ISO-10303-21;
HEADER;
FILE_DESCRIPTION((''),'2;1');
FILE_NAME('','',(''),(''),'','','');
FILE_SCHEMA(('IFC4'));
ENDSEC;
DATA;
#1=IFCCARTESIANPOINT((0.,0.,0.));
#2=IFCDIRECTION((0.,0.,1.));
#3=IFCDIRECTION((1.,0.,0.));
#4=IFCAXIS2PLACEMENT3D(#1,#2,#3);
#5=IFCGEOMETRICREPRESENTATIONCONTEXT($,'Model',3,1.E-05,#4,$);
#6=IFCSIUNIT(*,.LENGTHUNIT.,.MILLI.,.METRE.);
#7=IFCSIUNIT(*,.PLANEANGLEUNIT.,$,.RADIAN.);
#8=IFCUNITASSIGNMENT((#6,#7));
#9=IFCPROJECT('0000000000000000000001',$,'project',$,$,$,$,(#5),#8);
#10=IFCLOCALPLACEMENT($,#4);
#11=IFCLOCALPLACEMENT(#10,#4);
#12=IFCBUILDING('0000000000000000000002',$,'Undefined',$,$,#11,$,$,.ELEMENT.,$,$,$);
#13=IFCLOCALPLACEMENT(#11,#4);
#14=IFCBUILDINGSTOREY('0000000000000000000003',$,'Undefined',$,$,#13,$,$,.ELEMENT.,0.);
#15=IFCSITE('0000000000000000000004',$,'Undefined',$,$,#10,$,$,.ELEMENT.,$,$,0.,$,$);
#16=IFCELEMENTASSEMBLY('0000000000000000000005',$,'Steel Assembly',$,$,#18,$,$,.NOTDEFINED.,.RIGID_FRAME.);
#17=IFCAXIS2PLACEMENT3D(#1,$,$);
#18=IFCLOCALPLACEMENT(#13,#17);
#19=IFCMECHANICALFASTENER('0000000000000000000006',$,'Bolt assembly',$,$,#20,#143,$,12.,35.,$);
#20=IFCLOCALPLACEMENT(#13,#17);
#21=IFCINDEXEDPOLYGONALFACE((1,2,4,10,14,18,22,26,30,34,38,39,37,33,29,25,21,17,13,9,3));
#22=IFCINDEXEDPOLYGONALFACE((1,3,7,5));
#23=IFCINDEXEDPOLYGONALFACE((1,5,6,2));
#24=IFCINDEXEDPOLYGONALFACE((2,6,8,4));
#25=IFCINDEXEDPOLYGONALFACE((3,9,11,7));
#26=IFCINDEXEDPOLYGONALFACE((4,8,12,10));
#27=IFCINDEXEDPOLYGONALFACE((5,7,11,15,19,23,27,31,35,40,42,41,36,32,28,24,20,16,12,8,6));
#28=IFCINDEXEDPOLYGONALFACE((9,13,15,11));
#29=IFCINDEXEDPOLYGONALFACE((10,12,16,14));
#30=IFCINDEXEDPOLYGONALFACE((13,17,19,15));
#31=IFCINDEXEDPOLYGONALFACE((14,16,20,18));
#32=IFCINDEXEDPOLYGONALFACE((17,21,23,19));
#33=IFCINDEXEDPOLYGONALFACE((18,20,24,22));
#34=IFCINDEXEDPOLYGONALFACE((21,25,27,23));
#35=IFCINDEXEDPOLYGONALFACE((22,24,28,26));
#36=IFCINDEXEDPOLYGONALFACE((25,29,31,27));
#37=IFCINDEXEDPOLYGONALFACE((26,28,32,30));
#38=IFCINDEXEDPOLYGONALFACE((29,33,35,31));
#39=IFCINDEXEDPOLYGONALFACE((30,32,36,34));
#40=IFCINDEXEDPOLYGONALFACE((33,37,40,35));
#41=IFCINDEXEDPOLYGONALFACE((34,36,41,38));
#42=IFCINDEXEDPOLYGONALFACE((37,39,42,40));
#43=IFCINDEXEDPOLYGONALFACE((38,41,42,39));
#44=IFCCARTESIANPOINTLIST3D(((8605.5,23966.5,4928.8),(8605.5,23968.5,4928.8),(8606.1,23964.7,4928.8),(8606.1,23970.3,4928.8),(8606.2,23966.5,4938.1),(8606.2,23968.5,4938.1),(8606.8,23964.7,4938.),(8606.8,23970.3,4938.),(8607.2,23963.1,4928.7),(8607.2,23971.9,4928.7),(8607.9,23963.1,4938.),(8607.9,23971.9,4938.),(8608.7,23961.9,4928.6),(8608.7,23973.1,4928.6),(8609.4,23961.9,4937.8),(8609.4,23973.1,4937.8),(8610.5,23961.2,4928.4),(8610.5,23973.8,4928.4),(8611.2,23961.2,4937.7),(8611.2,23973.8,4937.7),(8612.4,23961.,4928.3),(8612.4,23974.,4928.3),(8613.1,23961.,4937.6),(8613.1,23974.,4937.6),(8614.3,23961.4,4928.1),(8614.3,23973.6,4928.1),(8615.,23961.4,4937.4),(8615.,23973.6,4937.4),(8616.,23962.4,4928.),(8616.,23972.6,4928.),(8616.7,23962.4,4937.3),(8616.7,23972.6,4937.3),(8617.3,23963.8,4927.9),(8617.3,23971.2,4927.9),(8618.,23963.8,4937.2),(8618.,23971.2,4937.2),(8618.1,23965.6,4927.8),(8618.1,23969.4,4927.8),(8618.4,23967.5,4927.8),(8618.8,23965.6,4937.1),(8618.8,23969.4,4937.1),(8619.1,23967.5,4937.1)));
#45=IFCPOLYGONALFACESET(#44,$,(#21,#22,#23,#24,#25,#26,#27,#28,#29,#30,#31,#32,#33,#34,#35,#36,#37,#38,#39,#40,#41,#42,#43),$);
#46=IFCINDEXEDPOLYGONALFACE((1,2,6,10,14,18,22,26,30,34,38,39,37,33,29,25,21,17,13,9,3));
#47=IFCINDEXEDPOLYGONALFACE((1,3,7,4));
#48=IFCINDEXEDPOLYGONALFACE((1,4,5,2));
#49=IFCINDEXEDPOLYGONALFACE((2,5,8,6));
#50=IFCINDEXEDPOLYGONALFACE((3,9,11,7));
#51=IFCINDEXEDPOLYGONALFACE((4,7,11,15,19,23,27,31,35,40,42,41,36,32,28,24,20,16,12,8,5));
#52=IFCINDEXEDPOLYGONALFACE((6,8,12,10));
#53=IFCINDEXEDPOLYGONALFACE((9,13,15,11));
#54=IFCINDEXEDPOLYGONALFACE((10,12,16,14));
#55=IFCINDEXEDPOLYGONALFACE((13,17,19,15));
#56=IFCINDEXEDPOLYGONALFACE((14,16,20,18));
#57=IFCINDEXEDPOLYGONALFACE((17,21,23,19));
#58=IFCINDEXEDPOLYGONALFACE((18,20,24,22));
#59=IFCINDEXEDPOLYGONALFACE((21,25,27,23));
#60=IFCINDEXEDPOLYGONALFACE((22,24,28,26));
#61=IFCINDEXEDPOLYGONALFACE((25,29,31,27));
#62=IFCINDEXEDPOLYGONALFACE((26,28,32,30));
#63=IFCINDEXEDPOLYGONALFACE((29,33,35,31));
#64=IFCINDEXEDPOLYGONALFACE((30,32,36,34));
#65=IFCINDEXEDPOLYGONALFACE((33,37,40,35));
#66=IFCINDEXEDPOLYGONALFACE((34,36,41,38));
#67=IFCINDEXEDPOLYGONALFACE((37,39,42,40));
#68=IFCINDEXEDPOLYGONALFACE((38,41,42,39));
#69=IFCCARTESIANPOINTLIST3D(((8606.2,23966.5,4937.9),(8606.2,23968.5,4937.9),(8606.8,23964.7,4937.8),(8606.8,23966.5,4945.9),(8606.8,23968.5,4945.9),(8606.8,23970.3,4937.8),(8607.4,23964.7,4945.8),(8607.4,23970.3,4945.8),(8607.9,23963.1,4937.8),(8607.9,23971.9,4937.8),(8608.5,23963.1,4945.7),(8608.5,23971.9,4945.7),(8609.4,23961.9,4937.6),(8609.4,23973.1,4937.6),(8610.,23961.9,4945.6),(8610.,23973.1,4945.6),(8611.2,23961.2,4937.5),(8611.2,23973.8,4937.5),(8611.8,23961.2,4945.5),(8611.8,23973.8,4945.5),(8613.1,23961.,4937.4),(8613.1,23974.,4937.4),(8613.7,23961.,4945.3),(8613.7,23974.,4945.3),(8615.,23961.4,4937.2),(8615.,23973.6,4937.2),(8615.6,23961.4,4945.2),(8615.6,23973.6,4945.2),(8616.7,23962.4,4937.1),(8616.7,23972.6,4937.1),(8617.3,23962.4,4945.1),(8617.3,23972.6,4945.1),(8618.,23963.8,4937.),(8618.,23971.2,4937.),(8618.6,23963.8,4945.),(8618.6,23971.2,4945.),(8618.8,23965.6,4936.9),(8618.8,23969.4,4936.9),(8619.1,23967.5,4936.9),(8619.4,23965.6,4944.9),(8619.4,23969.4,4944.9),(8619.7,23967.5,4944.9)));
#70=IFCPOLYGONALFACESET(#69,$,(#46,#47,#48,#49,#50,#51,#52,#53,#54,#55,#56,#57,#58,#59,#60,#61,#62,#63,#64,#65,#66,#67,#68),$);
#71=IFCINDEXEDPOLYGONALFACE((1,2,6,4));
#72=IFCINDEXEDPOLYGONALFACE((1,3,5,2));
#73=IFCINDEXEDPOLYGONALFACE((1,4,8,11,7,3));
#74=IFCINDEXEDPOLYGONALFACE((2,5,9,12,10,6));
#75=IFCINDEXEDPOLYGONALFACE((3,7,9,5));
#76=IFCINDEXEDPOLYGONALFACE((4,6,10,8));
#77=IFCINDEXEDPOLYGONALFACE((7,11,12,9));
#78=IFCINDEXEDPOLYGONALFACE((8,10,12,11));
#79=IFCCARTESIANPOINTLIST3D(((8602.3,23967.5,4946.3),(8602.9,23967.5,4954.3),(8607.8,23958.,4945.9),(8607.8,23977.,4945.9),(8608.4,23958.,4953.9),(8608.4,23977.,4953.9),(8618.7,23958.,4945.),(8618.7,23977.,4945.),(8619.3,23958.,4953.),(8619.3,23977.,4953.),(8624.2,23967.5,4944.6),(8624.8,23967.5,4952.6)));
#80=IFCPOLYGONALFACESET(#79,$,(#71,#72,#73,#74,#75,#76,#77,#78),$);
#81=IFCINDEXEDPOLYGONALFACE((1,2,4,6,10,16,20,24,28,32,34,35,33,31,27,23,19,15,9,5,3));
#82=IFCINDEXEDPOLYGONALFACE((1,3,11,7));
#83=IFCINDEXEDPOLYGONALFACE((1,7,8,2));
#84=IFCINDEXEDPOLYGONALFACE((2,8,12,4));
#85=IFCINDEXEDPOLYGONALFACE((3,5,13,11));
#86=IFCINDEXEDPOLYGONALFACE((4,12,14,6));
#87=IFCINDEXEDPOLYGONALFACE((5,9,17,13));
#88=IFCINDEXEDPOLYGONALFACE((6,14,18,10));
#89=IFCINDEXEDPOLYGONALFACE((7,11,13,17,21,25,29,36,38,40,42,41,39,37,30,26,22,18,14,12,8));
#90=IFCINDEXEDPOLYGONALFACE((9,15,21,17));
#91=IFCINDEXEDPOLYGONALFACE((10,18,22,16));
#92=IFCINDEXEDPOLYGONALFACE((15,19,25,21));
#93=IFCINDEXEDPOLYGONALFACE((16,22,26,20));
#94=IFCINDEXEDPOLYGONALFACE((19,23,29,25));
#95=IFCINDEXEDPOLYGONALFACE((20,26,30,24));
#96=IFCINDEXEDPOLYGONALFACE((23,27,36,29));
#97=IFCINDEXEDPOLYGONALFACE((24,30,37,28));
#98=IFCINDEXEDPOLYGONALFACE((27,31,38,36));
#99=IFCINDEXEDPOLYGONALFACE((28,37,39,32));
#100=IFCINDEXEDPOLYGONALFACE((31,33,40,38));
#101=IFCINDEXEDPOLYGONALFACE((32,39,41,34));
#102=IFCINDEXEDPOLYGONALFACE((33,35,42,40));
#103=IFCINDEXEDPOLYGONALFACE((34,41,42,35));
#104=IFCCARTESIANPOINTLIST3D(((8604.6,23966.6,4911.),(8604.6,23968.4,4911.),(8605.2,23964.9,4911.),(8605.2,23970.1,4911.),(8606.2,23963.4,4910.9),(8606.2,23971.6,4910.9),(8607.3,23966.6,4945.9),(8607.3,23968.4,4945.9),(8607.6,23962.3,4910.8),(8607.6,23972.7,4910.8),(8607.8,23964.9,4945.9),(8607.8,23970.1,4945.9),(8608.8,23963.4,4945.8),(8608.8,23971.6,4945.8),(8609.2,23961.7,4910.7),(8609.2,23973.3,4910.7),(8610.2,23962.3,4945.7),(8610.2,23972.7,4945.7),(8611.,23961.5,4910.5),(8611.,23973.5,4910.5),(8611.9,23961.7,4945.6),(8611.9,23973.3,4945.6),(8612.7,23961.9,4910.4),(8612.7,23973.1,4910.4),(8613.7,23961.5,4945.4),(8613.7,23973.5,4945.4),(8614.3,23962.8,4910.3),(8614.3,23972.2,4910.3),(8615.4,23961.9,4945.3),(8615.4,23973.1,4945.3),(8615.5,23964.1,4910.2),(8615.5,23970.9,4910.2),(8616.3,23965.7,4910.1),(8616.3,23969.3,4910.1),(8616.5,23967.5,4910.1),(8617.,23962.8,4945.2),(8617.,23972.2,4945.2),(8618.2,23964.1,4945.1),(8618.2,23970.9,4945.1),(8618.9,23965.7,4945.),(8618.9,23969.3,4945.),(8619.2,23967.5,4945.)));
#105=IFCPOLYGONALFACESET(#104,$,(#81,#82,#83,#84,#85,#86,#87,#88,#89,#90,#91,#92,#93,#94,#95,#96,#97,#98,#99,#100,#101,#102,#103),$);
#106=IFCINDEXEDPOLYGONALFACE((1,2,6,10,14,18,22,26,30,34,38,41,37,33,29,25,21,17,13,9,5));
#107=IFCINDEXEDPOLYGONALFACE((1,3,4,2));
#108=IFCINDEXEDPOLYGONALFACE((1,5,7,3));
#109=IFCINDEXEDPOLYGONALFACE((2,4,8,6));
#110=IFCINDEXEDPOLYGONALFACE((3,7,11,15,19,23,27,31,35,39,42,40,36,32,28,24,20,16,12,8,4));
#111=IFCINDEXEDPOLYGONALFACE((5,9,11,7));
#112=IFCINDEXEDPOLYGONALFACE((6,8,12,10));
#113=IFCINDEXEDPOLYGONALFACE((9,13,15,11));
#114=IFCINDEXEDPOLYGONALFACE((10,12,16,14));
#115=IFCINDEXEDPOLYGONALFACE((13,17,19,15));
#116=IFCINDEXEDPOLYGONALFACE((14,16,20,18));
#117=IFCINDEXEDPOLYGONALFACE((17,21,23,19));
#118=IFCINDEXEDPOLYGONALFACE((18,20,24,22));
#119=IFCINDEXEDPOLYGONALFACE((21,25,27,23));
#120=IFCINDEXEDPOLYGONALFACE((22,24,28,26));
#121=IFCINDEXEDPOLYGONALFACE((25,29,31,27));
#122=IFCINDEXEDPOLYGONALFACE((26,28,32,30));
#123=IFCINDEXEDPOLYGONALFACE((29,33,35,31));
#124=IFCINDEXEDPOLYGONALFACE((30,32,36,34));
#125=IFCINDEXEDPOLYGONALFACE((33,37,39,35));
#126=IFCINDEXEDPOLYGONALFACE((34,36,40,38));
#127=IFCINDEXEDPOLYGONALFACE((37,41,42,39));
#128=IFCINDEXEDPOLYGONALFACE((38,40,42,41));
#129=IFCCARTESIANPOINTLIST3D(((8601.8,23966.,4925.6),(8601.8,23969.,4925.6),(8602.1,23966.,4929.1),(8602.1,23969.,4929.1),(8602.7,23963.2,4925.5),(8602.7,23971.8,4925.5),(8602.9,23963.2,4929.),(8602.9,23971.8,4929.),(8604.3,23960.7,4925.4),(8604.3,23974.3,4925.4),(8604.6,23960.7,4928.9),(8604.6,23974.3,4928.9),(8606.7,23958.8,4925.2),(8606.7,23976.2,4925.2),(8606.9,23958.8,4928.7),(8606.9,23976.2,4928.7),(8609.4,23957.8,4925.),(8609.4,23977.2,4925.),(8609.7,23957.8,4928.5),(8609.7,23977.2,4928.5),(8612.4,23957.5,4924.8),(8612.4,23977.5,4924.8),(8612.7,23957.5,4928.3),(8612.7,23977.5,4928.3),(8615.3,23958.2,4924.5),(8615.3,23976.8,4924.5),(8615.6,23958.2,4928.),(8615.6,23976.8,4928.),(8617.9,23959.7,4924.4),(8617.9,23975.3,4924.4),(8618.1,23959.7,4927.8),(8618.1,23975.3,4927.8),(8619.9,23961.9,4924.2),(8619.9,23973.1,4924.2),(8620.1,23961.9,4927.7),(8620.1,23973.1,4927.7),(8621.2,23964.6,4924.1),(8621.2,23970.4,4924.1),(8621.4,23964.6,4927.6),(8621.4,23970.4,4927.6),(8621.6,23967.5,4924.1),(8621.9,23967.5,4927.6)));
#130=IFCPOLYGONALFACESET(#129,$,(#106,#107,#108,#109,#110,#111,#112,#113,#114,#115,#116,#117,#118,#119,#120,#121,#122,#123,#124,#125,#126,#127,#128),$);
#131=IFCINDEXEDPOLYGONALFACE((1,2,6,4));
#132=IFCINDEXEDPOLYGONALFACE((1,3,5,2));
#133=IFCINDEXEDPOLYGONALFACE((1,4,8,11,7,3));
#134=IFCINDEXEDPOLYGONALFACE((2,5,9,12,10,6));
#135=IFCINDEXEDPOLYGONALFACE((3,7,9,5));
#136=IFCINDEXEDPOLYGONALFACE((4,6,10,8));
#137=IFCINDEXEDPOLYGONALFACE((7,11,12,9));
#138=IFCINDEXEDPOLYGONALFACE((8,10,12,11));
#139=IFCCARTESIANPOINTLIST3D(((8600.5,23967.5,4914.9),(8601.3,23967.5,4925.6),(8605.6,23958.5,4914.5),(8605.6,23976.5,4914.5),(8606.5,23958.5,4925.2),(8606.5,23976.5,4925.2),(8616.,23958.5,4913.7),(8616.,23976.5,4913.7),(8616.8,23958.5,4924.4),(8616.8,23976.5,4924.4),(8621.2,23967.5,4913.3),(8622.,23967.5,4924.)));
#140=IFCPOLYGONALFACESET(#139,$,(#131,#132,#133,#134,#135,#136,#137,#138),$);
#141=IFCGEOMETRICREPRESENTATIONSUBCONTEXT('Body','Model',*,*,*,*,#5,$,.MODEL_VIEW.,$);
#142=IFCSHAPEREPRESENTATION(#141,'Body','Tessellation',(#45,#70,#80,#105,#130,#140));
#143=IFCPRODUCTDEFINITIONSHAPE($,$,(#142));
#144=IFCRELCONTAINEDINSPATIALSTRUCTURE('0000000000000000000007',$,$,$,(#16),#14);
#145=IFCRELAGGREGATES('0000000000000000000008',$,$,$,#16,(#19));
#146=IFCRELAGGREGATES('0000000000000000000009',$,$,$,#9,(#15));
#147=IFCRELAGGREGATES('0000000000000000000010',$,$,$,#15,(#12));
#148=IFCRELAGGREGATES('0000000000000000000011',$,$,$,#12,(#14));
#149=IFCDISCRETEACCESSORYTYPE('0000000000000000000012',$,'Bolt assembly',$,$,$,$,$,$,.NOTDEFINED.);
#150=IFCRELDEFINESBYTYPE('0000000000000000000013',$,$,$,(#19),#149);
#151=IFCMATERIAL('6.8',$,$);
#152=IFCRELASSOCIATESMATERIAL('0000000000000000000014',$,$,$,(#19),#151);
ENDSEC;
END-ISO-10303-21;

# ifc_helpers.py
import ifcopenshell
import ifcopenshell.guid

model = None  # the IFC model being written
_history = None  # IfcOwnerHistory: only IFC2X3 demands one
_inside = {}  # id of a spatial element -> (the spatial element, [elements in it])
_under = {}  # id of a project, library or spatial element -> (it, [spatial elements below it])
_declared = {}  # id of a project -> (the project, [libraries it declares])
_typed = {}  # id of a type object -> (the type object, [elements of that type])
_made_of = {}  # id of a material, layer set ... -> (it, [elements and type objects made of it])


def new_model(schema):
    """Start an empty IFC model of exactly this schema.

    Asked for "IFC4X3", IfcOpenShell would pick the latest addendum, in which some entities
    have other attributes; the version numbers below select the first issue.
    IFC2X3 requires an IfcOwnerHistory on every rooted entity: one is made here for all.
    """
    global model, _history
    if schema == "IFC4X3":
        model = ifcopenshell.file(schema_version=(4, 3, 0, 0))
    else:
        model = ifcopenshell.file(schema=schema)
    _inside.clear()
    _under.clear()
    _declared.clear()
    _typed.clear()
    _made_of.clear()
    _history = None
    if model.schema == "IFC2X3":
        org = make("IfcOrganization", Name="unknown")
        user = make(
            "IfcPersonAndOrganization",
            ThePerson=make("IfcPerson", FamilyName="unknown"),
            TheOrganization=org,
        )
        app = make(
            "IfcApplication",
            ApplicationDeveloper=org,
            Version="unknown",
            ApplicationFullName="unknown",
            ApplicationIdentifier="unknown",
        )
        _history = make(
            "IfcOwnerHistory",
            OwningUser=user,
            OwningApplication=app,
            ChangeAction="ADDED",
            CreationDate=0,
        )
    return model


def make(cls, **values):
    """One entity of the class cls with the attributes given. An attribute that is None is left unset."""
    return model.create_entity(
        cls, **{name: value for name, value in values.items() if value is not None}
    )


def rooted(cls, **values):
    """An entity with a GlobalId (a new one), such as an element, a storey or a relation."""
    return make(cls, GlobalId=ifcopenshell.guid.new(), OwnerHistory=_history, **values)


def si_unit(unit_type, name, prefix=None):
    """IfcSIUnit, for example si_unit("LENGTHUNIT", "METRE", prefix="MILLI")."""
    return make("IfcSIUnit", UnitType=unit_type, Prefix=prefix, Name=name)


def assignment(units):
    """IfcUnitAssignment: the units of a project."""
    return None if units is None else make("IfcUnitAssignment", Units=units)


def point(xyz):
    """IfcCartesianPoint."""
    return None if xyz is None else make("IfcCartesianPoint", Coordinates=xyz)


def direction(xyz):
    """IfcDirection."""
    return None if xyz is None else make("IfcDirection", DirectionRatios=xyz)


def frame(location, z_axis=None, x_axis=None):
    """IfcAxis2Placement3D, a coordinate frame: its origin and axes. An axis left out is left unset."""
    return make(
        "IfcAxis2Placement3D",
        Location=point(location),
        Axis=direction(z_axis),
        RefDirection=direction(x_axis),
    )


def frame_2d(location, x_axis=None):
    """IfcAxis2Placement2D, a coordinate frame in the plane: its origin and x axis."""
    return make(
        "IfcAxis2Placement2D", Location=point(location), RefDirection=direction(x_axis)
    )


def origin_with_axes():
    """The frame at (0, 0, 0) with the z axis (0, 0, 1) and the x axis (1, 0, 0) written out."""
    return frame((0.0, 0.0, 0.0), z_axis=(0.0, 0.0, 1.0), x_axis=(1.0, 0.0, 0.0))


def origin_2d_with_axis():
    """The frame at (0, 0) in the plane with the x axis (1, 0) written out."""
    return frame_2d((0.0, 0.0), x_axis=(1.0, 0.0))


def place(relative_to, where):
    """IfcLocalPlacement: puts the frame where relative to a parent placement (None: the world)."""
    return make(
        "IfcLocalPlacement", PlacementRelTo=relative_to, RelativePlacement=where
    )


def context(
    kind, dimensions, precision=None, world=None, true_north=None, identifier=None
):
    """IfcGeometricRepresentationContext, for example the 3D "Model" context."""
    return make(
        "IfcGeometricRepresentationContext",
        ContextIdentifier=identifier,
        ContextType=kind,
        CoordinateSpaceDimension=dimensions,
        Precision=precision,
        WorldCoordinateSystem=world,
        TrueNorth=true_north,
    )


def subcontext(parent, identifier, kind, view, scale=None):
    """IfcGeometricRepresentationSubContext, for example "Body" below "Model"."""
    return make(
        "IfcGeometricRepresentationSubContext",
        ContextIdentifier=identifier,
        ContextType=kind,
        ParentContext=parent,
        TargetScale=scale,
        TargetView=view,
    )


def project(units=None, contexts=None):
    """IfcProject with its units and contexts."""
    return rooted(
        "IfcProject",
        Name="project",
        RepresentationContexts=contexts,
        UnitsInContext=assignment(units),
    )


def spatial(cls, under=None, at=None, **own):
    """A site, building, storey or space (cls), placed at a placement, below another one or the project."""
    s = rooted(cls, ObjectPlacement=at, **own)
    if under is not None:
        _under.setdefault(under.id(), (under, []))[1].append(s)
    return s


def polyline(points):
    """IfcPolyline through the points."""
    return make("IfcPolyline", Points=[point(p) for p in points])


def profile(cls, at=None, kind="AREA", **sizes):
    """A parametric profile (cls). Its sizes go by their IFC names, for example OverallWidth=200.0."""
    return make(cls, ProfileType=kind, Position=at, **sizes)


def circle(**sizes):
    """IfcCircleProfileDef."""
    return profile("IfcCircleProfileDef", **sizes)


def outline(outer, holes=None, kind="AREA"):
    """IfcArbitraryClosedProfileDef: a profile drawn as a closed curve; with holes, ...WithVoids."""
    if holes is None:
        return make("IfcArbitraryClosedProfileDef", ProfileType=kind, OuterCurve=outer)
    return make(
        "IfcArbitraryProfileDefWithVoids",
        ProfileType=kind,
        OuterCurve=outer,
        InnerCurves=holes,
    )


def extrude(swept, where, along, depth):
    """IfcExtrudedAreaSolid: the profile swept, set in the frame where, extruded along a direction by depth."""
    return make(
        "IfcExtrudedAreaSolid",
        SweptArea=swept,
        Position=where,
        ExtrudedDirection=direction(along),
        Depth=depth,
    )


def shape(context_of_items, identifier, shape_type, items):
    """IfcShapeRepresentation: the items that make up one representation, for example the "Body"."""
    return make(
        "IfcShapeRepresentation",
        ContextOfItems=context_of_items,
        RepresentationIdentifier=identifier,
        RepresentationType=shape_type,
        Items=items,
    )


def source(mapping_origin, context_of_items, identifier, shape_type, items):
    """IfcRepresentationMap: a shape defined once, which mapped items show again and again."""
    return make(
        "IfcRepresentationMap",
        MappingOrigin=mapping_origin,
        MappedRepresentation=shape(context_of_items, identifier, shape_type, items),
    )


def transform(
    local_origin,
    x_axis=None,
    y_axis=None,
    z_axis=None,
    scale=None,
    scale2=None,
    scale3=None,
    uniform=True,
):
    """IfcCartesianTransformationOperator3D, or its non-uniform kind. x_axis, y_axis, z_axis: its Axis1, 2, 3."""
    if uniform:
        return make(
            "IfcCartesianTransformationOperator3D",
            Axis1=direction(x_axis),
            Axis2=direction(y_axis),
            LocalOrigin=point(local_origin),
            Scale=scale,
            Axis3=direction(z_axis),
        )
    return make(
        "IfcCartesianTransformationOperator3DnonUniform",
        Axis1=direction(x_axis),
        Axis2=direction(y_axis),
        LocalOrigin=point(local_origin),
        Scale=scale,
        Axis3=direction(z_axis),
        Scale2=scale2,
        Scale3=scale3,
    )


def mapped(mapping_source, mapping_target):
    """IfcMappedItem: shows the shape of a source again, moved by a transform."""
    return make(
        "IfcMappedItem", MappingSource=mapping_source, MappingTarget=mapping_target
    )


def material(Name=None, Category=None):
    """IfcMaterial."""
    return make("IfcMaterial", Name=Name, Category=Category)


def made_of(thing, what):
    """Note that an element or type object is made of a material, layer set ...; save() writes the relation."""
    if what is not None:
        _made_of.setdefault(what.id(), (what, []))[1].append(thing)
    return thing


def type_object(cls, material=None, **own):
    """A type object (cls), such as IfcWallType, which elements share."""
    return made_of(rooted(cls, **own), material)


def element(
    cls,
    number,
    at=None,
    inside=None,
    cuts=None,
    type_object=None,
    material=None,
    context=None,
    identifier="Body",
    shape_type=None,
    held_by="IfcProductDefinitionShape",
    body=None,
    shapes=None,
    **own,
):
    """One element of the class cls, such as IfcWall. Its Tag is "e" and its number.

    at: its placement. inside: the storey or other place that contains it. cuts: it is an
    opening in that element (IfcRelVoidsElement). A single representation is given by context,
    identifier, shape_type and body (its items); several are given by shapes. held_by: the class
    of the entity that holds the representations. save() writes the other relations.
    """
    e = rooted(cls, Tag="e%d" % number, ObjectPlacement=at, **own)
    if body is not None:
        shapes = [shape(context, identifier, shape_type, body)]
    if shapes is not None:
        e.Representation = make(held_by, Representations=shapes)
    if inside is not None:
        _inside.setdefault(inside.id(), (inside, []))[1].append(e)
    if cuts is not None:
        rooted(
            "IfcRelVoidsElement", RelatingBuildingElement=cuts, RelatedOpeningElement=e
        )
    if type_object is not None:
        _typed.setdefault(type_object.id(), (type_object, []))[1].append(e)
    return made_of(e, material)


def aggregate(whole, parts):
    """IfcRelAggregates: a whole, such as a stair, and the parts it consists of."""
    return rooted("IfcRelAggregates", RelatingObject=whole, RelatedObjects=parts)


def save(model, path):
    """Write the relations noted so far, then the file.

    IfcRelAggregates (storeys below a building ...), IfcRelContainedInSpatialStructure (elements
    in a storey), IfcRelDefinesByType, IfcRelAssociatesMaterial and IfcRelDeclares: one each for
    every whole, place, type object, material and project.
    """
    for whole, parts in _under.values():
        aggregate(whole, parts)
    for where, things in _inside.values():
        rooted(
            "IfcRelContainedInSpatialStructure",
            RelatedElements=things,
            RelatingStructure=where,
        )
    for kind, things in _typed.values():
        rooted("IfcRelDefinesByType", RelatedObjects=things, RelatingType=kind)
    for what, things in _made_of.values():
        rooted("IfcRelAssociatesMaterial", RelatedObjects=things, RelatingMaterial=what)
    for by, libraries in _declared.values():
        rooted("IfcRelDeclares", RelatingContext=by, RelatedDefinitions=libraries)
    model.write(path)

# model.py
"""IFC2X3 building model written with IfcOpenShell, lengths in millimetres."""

from ifc_helpers import new_model, si_unit, frame, origin_with_axes, origin_2d_with_axis, place, context, subcontext, project, spatial, polyline, circle, outline, extrude, source, transform, mapped, material, type_object, element, aggregate, save


model = new_model("IFC2X3")

# Units and contexts
model_context = context("Model", 3, precision=1e-05, world=origin_with_axes())
body_context = subcontext(model_context, "Body", "Model", "MODEL_VIEW")
ifc_project = project(units=[si_unit("LENGTHUNIT", "METRE", prefix="MILLI"), si_unit("PLANEANGLEUNIT", "RADIAN")], contexts=[model_context])

# Site, building, storey
site_placement = place(None, origin_with_axes())
site = spatial("IfcSite", under=ifc_project, at=site_placement, Name="Undefined", CompositionType="ELEMENT", RefElevation=0.0)
building_placement = place(site_placement, origin_with_axes())
building = spatial("IfcBuilding", under=site, at=building_placement, Name="Undefined", CompositionType="ELEMENT")
storey_placement = place(building_placement, origin_with_axes())
storey = spatial("IfcBuildingStorey", under=building, at=storey_placement, Name="Undefined", CompositionType="ELEMENT", Elevation=0.0)

# Shared definitions
ifc_material_1 = material(Name="6.8")
discrete_accessory_type_1 = type_object("IfcDiscreteAccessoryType", Name="Bolt assembly")

# Element assembly, mechanical fastener
shared_shape_1 = source(origin_with_axes(), body_context, "Body", "SweptSolid", [
    extrude(circle(Radius=6.5, at=origin_2d_with_axis()), frame((0.0, -0.1, 0.0), z_axis=(0.0, 1.0, 0.0), x_axis=(1.0, 0.0, 0.0)), (0.0, 0.0, 1.0), 9.3),
    extrude(circle(Radius=6.5, at=origin_2d_with_axis()), frame((0.0, -7.9, 0.0), z_axis=(0.0, 1.0, 0.0), x_axis=(1.0, 0.0, 0.0)), (0.0, 0.0, 1.0), 8.0),
    extrude(outline(polyline([(11.0, 0.0), (5.5, 9.5), (-5.5, 9.5), (-11.0, 0.0), (-5.5, -9.5), (5.5, -9.5), (11.0, 0.0)])), frame((0.0, -16.0, 0.0), z_axis=(0.0, 1.0, 0.0), x_axis=(1.0, 0.0, 0.0)), (0.0, 0.0, 1.0), 8.0),
    extrude(circle(Radius=6.0, at=origin_2d_with_axis()), frame((0.0, -8.0, 0.0), z_axis=(0.0, 1.0, 0.0), x_axis=(1.0, 0.0, 0.0)), (0.0, 0.0, 1.0), 35.0),
    extrude(circle(Radius=10.0, at=origin_2d_with_axis()), frame((0.0, 9.2, 0.0), z_axis=(0.0, 1.0, 0.0), x_axis=(1.0, 0.0, 0.0)), (0.0, 0.0, 1.0), 3.5),
    extrude(outline(polyline([(10.4, 0.0), (5.2, 9.0), (-5.2, 9.0), (-10.4, 0.0), (-5.2, -9.0), (5.2, -9.0), (10.4, 0.0)])), frame((0.0, 12.7, 0.0), z_axis=(0.0, 1.0, 0.0), x_axis=(1.0, 0.0, 0.0)), (0.0, 0.0, 1.0), 10.8),
])
assembly_1_placement = place(storey_placement, origin_with_axes())
assembly_1 = element("IfcElementAssembly", 1, at=assembly_1_placement, inside=storey, Name="Steel Assembly", AssemblyPlace="NOTDEFINED", PredefinedType="RIGID_FRAME")
mechanical_fastener_1_placement = place(assembly_1_placement, frame((8612.6, 23967.5, 4937.5), z_axis=(0.0, 1.0, 0.0), x_axis=(0.997054, 0.0, -0.076696)))
mechanical_fastener_1 = element("IfcMechanicalFastener", 2, at=mechanical_fastener_1_placement, type_object=discrete_accessory_type_1, material=ifc_material_1, Name="Bolt assembly", NominalDiameter=12.0, NominalLength=35.0, context=body_context, shape_type="MappedRepresentation", body=[
    mapped(shared_shape_1, transform((0.0, 0.0, 0.0))),
])
aggregate(assembly_1, [mechanical_fastener_1])

save(model, "model.ifc")
